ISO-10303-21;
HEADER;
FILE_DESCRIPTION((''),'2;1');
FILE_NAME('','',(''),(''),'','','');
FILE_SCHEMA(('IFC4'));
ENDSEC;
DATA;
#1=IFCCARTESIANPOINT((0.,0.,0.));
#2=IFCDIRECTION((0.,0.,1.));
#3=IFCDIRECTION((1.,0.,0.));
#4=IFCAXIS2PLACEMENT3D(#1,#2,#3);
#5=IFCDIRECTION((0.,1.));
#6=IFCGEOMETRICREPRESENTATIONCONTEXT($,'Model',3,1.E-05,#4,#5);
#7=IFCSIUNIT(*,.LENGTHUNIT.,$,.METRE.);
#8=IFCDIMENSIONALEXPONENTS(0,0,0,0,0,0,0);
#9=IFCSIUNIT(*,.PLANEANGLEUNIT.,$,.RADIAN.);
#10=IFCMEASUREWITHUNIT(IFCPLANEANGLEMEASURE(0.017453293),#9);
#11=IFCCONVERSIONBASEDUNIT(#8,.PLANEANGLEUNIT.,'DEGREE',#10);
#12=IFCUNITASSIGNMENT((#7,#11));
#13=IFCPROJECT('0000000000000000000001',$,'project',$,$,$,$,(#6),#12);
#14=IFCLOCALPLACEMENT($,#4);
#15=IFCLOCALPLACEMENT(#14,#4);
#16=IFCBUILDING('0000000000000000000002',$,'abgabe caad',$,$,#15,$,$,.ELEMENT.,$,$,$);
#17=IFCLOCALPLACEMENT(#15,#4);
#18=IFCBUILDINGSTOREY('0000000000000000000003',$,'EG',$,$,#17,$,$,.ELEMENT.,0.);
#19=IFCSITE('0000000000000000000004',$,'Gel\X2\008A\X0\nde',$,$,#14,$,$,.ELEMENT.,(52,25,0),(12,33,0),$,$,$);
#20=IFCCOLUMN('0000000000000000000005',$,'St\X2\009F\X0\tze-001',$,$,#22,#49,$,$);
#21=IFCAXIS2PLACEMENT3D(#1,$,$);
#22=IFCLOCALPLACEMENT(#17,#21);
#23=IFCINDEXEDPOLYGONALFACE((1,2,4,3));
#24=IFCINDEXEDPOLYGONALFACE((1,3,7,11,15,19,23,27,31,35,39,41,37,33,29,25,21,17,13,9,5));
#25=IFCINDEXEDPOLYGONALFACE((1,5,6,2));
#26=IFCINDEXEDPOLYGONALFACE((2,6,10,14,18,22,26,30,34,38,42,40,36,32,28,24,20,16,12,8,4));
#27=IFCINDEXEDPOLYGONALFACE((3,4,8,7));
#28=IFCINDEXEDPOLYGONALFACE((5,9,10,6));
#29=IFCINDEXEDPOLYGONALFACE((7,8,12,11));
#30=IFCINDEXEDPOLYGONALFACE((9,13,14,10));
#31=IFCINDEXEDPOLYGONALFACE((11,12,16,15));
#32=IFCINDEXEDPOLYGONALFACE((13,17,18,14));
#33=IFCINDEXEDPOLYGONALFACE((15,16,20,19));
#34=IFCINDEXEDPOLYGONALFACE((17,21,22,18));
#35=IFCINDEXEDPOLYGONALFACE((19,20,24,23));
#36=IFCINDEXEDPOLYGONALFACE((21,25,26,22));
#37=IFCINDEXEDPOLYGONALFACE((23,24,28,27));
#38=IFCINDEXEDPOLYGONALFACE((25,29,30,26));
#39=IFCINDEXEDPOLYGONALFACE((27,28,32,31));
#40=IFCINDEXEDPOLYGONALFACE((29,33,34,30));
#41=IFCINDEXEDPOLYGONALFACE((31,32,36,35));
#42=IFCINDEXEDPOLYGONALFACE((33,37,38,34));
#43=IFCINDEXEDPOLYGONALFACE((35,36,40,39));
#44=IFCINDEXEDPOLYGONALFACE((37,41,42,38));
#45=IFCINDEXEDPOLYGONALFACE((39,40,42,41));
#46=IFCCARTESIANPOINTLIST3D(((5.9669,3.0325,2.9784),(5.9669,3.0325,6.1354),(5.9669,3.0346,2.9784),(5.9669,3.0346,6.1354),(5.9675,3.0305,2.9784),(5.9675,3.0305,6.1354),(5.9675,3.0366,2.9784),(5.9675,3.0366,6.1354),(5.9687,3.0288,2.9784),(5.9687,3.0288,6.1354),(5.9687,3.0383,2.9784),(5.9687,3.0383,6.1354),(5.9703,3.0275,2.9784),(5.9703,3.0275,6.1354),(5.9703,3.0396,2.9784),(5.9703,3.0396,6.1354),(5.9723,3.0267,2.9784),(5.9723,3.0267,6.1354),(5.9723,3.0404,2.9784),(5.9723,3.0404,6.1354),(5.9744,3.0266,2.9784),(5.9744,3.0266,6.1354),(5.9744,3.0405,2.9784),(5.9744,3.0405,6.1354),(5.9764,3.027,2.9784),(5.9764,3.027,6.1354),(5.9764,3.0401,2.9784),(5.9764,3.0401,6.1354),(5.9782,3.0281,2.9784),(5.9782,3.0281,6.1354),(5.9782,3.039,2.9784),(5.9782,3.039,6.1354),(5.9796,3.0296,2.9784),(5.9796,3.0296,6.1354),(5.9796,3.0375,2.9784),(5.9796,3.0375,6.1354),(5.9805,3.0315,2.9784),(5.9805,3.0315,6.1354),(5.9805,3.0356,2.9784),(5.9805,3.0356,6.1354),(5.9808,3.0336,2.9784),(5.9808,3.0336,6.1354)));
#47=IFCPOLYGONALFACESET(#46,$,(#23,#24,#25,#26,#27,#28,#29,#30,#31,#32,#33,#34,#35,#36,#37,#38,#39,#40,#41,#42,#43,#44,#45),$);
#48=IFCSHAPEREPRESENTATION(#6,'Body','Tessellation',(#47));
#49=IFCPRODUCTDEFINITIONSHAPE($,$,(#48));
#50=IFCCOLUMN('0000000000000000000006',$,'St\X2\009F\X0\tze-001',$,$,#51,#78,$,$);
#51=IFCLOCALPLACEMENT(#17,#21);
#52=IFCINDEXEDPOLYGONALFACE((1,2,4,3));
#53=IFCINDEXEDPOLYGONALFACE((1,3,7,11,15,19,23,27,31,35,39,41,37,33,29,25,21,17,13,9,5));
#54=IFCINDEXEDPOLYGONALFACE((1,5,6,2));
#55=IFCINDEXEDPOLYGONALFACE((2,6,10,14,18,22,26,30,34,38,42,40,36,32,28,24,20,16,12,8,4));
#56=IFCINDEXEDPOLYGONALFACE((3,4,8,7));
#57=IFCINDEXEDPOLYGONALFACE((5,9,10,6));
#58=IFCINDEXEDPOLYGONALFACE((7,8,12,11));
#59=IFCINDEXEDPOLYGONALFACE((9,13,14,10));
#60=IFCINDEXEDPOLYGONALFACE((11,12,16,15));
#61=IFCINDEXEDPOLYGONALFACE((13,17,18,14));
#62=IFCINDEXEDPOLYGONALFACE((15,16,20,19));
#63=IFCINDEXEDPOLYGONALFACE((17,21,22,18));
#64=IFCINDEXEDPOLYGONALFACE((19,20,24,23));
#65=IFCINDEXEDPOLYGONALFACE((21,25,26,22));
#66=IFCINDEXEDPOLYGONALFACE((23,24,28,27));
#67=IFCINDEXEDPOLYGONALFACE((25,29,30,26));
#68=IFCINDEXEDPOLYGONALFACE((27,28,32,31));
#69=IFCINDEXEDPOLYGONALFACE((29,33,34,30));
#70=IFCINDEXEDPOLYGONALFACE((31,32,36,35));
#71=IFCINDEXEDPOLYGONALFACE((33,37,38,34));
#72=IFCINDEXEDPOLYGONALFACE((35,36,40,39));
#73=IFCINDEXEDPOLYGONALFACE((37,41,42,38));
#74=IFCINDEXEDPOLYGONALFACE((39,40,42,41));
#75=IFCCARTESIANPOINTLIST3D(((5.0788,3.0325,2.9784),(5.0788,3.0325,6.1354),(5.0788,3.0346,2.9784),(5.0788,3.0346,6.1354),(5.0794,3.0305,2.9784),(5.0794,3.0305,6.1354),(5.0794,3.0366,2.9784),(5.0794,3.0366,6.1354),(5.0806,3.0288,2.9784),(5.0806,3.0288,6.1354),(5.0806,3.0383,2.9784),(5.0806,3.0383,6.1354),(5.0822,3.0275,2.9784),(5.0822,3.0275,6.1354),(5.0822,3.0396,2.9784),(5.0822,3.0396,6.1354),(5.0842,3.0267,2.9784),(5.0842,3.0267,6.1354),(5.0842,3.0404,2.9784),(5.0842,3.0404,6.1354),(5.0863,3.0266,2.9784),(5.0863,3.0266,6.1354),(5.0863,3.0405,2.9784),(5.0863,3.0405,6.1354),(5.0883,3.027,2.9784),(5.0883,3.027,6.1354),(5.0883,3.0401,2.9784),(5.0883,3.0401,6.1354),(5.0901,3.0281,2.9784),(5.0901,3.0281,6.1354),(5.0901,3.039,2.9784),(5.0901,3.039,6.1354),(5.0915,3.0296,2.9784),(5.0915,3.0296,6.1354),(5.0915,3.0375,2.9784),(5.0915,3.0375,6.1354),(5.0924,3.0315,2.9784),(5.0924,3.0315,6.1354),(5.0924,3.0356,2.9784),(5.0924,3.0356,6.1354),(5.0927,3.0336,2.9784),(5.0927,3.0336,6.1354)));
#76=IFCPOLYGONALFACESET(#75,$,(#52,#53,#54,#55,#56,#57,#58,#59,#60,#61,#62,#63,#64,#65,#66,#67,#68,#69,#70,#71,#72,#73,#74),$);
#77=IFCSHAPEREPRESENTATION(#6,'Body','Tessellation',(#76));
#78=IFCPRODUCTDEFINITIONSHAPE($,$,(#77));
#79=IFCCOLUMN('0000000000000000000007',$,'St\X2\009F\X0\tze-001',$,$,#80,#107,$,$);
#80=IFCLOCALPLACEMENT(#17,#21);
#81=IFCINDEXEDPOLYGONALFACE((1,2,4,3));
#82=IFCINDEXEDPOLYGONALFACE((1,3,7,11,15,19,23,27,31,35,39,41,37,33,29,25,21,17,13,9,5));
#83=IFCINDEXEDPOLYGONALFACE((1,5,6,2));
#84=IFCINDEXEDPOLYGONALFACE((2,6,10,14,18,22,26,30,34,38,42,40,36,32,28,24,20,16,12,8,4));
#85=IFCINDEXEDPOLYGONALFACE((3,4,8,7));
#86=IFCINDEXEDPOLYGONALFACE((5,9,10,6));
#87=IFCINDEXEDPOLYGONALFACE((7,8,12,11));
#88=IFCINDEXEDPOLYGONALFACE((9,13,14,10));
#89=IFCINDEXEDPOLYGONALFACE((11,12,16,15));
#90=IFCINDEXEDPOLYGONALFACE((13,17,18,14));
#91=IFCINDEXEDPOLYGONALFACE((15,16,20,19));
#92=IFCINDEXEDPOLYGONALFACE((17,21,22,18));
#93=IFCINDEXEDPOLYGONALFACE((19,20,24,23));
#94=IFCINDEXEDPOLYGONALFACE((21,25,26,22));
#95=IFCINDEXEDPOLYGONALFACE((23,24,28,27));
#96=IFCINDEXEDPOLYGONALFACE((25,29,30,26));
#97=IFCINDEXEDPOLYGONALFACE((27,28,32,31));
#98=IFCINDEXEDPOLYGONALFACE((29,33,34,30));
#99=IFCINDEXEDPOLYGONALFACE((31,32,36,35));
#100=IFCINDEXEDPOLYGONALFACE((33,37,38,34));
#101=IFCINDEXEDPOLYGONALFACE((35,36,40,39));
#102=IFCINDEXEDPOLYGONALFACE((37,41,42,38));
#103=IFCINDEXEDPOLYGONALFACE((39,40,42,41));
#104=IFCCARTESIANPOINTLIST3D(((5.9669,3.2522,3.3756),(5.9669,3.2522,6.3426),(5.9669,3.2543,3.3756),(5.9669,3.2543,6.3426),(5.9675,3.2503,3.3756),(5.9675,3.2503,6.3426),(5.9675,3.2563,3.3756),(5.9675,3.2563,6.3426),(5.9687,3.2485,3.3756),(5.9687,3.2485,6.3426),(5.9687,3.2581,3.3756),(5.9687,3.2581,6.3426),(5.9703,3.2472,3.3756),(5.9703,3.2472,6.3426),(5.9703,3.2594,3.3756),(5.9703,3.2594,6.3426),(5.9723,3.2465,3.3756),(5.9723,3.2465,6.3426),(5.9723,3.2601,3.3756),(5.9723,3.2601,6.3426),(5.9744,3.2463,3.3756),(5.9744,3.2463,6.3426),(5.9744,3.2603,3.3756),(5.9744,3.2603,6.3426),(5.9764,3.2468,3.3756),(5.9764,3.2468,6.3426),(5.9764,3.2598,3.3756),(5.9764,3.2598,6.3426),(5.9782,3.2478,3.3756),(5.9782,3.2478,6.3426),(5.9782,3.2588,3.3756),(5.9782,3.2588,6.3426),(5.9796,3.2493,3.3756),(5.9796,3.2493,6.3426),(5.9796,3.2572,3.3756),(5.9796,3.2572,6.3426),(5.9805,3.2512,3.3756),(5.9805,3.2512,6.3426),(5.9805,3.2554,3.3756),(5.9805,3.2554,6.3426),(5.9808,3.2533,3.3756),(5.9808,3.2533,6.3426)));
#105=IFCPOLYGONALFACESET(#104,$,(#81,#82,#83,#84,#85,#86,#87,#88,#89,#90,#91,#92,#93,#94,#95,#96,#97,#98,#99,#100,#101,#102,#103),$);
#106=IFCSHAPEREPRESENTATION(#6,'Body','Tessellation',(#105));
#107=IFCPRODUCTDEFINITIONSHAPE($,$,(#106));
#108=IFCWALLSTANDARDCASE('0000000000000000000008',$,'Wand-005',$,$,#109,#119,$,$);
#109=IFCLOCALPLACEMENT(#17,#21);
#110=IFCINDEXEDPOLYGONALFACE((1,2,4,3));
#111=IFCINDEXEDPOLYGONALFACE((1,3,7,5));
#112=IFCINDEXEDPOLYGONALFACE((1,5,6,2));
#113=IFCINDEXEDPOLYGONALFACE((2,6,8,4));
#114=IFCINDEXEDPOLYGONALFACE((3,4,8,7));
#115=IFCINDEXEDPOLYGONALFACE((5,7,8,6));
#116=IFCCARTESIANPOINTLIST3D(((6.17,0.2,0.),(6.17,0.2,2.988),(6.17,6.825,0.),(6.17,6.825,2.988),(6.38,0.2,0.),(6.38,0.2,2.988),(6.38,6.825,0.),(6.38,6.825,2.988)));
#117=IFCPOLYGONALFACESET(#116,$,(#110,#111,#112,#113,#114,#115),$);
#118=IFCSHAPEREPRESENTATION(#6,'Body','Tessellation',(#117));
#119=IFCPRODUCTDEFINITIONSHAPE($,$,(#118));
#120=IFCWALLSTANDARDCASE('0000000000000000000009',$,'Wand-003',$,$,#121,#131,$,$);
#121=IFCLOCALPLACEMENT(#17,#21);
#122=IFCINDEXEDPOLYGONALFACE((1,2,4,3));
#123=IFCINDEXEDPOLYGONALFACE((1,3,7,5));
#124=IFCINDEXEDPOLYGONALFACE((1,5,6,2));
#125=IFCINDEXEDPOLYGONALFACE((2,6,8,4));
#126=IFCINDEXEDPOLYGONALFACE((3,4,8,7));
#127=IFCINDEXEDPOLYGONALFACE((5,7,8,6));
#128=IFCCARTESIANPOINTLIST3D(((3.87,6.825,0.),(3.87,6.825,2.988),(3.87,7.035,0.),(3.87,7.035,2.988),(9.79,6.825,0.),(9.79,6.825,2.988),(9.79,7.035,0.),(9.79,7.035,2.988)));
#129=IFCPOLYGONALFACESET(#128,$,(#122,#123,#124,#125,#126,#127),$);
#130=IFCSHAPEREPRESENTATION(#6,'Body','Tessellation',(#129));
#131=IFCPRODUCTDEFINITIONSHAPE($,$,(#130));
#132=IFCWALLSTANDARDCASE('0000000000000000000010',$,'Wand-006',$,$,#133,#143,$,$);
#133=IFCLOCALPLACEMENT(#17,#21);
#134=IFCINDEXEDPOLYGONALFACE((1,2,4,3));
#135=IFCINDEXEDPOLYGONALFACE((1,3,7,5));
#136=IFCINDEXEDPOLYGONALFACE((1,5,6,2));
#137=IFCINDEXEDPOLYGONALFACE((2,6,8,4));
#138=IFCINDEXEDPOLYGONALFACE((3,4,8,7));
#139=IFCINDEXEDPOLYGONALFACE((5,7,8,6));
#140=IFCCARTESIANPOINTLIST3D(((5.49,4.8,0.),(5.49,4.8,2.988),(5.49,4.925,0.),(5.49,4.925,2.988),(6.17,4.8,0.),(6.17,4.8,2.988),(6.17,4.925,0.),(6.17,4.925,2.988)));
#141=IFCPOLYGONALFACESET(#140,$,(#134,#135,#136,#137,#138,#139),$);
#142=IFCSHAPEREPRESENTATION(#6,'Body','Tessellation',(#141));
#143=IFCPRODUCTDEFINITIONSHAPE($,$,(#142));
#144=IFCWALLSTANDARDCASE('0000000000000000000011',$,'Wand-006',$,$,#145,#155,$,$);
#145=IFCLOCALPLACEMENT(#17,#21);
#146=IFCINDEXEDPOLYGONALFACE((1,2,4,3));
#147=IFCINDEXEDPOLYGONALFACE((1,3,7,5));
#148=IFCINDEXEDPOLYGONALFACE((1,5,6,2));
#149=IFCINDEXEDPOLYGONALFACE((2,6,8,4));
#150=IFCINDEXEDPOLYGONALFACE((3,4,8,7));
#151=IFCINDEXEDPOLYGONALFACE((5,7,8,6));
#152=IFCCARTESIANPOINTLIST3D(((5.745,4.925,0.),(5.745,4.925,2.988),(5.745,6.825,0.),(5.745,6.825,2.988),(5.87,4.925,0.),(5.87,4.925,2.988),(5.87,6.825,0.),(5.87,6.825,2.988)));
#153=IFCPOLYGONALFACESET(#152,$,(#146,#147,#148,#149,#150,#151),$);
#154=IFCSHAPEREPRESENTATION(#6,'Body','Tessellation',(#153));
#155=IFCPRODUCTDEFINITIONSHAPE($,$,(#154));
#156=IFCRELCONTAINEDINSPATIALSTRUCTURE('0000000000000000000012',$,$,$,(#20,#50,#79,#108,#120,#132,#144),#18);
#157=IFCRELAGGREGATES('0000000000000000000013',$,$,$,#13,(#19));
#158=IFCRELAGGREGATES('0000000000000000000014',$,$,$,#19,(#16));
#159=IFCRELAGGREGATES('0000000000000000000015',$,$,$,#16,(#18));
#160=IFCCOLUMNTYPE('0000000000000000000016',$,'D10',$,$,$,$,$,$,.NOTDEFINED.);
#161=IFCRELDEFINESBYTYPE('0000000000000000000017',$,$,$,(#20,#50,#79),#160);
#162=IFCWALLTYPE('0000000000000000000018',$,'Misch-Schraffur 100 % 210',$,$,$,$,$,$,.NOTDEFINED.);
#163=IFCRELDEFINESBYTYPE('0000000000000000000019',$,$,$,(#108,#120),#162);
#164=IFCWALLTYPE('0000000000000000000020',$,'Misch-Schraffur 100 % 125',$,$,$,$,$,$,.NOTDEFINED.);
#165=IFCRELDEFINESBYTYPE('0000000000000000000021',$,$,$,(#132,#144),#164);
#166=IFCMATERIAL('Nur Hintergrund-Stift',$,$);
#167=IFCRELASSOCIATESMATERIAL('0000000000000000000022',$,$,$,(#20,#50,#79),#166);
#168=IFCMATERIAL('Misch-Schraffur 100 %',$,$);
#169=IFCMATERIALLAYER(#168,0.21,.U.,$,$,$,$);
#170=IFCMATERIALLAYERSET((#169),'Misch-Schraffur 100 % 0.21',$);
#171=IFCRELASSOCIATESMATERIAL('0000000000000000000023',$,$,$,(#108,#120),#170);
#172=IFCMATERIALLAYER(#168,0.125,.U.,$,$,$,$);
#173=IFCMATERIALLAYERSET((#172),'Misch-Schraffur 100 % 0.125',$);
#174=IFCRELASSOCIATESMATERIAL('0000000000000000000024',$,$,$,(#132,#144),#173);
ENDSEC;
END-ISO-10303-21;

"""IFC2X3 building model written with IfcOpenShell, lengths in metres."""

from ifc_helpers import new_model, entity, si_unit, converted_unit, direction, frame, origin_with_axes, origin_2d_with_axis, place, context, project, spatial, polyline, circle, outline, extrude, material, layer, layer_set, layer_usage, type_object, element, save


model = new_model("IFC2X3")

# Units and contexts
model_context = context("Model", 3, precision=1e-05, world=origin_with_axes(), true_north=direction((0.0, 1.0)))
ifc_project = project(units=[si_unit("LENGTHUNIT", "METRE"), converted_unit("PLANEANGLEUNIT", "DEGREE", entity("IfcPlaneAngleMeasure", 0.017453293), si_unit("PLANEANGLEUNIT", "RADIAN"), dimensions=[0, 0, 0, 0, 0, 0, 0])], contexts=[model_context])

# Site, building, storey
site_placement = place(None, origin_with_axes())
site = spatial("IfcSite", under=ifc_project, at=site_placement, Name="Gel\u008ande", CompositionType="ELEMENT", RefLatitude=(52, 25, 0), RefLongitude=(12, 33, 0))
building_placement = place(site_placement, origin_with_axes())
building = spatial("IfcBuilding", under=site, at=building_placement, Name="abgabe caad", CompositionType="ELEMENT")
storey_placement = place(building_placement, origin_with_axes())
storey = spatial("IfcBuildingStorey", under=building, at=storey_placement, Name="EG", CompositionType="ELEMENT", Elevation=0.0)

# Columns
ifc_material_1 = material(Name="Nur Hintergrund-Stift")
column_type = type_object("IfcColumnType", Name="D10", PredefinedType="NOTDEFINED")
for number, where, z_axis, x_axis, name in (
    (1, (5.9738, 3.0336, 2.9784), (0.0, 0.0, 1.0), (1.0, 0.0, 0.0), "St\u009ftze-001"),
    (2, (5.0857, 3.0336, 2.9784), (0.0, 0.0, 1.0), (1.0, 0.0, 0.0), "St\u009ftze-001"),
):
    element("IfcColumn", number, at=place(storey_placement, frame(where, z_axis=z_axis, x_axis=x_axis)), inside=storey, type_object=column_type, material=ifc_material_1, Name=name, context=model_context, shape_type="SweptSolid", body=[
        extrude(circle(Radius=0.007, at=origin_2d_with_axis()), origin_with_axes(), (0.0, 0.0, 1.0), 3.157),
    ])
column_placement = place(storey_placement, frame((5.9738, 3.2533, 3.3756), z_axis=(0.0, 0.0, 1.0), x_axis=(1.0, 0.0, 0.0)))
element("IfcColumn", 3, at=column_placement, inside=storey, type_object=column_type, material=ifc_material_1, Name="St\u009ftze-001", context=model_context, shape_type="SweptSolid", body=[
    extrude(circle(Radius=0.007, at=origin_2d_with_axis()), origin_with_axes(), (0.0, 0.0, 1.0), 2.967),
])

# Walls
ifc_material_2 = material(Name="Misch-Schraffur 100 %")
ifc_layer_1 = layer(ifc_material_2, 0.21, ventilated="UNKNOWN")
ifc_layer_set_1 = layer_set([ifc_layer_1], Name="Misch-Schraffur 100 % 0.21")
ifc_layer_usage_1 = layer_usage(ifc_layer_set_1, "AXIS2", "NEGATIVE", 0.0)
wall_type_1 = type_object("IfcWallType", Name="Misch-Schraffur 100 % 210", PredefinedType="NOTDEFINED")
wall_1_placement = place(storey_placement, frame((6.38, 6.825, 0.0), z_axis=(0.0, 0.0, 1.0), x_axis=(0.0, -1.0, 0.0)))
element("IfcWallStandardCase", 4, at=wall_1_placement, inside=storey, type_object=wall_type_1, material=ifc_layer_usage_1, Name="Wand-005", context=model_context, shape_type="SweptSolid", body=[
    extrude(outline(polyline([(0.0, -0.21), (6.625, -0.21), (6.625, 0.0), (0.0, 0.0), (0.0, -0.21)])), origin_with_axes(), (0.0, 0.0, 1.0), 2.988),
])
ifc_layer_usage_2 = layer_usage(ifc_layer_set_1, "AXIS2", "NEGATIVE", 0.0)
wall_2_placement = place(storey_placement, frame((9.79, 6.825, 0.0), z_axis=(0.0, 0.0, 1.0), x_axis=(-1.0, 0.0, 0.0)))
element("IfcWallStandardCase", 5, at=wall_2_placement, inside=storey, type_object=wall_type_1, material=ifc_layer_usage_2, Name="Wand-003", context=model_context, shape_type="SweptSolid", body=[
    extrude(outline(polyline([(0.0, -0.21), (5.92, -0.21), (5.92, 0.0), (0.0, 0.0), (0.0, -0.21)])), origin_with_axes(), (0.0, 0.0, 1.0), 2.988),
])
ifc_layer_2 = layer(ifc_material_2, 0.125, ventilated="UNKNOWN")
ifc_layer_set_2 = layer_set([ifc_layer_2], Name="Misch-Schraffur 100 % 0.125")
ifc_layer_usage_3 = layer_usage(ifc_layer_set_2, "AXIS2", "POSITIVE", 0.0)
wall_type_2 = type_object("IfcWallType", Name="Misch-Schraffur 100 % 125", PredefinedType="NOTDEFINED")
wall_3_placement = place(storey_placement, frame((5.49, 4.8, 0.0), z_axis=(0.0, 0.0, 1.0), x_axis=(1.0, 0.0, 0.0)))
element("IfcWallStandardCase", 6, at=wall_3_placement, inside=storey, type_object=wall_type_2, material=ifc_layer_usage_3, Name="Wand-006", context=model_context, shape_type="SweptSolid", body=[
    extrude(outline(polyline([(0.0, 0.0), (0.68, 0.0), (0.68, 0.125), (0.0, 0.125), (0.0, 0.0)])), origin_with_axes(), (0.0, 0.0, 1.0), 2.988),
])
ifc_layer_usage_4 = layer_usage(ifc_layer_set_2, "AXIS2", "POSITIVE", 0.0)
wall_4_placement = place(storey_placement, frame((5.87, 4.925, 0.0), z_axis=(0.0, 0.0, 1.0), x_axis=(0.0, 1.0, 0.0)))
element("IfcWallStandardCase", 7, at=wall_4_placement, inside=storey, type_object=wall_type_2, material=ifc_layer_usage_4, Name="Wand-006", context=model_context, shape_type="SweptSolid", body=[
    extrude(outline(polyline([(0.0, 0.0), (1.9, 0.0), (1.9, 0.125), (0.0, 0.125), (0.0, 0.0)])), origin_with_axes(), (0.0, 0.0, 1.0), 2.988),
])

save(model, "model.ifc")
